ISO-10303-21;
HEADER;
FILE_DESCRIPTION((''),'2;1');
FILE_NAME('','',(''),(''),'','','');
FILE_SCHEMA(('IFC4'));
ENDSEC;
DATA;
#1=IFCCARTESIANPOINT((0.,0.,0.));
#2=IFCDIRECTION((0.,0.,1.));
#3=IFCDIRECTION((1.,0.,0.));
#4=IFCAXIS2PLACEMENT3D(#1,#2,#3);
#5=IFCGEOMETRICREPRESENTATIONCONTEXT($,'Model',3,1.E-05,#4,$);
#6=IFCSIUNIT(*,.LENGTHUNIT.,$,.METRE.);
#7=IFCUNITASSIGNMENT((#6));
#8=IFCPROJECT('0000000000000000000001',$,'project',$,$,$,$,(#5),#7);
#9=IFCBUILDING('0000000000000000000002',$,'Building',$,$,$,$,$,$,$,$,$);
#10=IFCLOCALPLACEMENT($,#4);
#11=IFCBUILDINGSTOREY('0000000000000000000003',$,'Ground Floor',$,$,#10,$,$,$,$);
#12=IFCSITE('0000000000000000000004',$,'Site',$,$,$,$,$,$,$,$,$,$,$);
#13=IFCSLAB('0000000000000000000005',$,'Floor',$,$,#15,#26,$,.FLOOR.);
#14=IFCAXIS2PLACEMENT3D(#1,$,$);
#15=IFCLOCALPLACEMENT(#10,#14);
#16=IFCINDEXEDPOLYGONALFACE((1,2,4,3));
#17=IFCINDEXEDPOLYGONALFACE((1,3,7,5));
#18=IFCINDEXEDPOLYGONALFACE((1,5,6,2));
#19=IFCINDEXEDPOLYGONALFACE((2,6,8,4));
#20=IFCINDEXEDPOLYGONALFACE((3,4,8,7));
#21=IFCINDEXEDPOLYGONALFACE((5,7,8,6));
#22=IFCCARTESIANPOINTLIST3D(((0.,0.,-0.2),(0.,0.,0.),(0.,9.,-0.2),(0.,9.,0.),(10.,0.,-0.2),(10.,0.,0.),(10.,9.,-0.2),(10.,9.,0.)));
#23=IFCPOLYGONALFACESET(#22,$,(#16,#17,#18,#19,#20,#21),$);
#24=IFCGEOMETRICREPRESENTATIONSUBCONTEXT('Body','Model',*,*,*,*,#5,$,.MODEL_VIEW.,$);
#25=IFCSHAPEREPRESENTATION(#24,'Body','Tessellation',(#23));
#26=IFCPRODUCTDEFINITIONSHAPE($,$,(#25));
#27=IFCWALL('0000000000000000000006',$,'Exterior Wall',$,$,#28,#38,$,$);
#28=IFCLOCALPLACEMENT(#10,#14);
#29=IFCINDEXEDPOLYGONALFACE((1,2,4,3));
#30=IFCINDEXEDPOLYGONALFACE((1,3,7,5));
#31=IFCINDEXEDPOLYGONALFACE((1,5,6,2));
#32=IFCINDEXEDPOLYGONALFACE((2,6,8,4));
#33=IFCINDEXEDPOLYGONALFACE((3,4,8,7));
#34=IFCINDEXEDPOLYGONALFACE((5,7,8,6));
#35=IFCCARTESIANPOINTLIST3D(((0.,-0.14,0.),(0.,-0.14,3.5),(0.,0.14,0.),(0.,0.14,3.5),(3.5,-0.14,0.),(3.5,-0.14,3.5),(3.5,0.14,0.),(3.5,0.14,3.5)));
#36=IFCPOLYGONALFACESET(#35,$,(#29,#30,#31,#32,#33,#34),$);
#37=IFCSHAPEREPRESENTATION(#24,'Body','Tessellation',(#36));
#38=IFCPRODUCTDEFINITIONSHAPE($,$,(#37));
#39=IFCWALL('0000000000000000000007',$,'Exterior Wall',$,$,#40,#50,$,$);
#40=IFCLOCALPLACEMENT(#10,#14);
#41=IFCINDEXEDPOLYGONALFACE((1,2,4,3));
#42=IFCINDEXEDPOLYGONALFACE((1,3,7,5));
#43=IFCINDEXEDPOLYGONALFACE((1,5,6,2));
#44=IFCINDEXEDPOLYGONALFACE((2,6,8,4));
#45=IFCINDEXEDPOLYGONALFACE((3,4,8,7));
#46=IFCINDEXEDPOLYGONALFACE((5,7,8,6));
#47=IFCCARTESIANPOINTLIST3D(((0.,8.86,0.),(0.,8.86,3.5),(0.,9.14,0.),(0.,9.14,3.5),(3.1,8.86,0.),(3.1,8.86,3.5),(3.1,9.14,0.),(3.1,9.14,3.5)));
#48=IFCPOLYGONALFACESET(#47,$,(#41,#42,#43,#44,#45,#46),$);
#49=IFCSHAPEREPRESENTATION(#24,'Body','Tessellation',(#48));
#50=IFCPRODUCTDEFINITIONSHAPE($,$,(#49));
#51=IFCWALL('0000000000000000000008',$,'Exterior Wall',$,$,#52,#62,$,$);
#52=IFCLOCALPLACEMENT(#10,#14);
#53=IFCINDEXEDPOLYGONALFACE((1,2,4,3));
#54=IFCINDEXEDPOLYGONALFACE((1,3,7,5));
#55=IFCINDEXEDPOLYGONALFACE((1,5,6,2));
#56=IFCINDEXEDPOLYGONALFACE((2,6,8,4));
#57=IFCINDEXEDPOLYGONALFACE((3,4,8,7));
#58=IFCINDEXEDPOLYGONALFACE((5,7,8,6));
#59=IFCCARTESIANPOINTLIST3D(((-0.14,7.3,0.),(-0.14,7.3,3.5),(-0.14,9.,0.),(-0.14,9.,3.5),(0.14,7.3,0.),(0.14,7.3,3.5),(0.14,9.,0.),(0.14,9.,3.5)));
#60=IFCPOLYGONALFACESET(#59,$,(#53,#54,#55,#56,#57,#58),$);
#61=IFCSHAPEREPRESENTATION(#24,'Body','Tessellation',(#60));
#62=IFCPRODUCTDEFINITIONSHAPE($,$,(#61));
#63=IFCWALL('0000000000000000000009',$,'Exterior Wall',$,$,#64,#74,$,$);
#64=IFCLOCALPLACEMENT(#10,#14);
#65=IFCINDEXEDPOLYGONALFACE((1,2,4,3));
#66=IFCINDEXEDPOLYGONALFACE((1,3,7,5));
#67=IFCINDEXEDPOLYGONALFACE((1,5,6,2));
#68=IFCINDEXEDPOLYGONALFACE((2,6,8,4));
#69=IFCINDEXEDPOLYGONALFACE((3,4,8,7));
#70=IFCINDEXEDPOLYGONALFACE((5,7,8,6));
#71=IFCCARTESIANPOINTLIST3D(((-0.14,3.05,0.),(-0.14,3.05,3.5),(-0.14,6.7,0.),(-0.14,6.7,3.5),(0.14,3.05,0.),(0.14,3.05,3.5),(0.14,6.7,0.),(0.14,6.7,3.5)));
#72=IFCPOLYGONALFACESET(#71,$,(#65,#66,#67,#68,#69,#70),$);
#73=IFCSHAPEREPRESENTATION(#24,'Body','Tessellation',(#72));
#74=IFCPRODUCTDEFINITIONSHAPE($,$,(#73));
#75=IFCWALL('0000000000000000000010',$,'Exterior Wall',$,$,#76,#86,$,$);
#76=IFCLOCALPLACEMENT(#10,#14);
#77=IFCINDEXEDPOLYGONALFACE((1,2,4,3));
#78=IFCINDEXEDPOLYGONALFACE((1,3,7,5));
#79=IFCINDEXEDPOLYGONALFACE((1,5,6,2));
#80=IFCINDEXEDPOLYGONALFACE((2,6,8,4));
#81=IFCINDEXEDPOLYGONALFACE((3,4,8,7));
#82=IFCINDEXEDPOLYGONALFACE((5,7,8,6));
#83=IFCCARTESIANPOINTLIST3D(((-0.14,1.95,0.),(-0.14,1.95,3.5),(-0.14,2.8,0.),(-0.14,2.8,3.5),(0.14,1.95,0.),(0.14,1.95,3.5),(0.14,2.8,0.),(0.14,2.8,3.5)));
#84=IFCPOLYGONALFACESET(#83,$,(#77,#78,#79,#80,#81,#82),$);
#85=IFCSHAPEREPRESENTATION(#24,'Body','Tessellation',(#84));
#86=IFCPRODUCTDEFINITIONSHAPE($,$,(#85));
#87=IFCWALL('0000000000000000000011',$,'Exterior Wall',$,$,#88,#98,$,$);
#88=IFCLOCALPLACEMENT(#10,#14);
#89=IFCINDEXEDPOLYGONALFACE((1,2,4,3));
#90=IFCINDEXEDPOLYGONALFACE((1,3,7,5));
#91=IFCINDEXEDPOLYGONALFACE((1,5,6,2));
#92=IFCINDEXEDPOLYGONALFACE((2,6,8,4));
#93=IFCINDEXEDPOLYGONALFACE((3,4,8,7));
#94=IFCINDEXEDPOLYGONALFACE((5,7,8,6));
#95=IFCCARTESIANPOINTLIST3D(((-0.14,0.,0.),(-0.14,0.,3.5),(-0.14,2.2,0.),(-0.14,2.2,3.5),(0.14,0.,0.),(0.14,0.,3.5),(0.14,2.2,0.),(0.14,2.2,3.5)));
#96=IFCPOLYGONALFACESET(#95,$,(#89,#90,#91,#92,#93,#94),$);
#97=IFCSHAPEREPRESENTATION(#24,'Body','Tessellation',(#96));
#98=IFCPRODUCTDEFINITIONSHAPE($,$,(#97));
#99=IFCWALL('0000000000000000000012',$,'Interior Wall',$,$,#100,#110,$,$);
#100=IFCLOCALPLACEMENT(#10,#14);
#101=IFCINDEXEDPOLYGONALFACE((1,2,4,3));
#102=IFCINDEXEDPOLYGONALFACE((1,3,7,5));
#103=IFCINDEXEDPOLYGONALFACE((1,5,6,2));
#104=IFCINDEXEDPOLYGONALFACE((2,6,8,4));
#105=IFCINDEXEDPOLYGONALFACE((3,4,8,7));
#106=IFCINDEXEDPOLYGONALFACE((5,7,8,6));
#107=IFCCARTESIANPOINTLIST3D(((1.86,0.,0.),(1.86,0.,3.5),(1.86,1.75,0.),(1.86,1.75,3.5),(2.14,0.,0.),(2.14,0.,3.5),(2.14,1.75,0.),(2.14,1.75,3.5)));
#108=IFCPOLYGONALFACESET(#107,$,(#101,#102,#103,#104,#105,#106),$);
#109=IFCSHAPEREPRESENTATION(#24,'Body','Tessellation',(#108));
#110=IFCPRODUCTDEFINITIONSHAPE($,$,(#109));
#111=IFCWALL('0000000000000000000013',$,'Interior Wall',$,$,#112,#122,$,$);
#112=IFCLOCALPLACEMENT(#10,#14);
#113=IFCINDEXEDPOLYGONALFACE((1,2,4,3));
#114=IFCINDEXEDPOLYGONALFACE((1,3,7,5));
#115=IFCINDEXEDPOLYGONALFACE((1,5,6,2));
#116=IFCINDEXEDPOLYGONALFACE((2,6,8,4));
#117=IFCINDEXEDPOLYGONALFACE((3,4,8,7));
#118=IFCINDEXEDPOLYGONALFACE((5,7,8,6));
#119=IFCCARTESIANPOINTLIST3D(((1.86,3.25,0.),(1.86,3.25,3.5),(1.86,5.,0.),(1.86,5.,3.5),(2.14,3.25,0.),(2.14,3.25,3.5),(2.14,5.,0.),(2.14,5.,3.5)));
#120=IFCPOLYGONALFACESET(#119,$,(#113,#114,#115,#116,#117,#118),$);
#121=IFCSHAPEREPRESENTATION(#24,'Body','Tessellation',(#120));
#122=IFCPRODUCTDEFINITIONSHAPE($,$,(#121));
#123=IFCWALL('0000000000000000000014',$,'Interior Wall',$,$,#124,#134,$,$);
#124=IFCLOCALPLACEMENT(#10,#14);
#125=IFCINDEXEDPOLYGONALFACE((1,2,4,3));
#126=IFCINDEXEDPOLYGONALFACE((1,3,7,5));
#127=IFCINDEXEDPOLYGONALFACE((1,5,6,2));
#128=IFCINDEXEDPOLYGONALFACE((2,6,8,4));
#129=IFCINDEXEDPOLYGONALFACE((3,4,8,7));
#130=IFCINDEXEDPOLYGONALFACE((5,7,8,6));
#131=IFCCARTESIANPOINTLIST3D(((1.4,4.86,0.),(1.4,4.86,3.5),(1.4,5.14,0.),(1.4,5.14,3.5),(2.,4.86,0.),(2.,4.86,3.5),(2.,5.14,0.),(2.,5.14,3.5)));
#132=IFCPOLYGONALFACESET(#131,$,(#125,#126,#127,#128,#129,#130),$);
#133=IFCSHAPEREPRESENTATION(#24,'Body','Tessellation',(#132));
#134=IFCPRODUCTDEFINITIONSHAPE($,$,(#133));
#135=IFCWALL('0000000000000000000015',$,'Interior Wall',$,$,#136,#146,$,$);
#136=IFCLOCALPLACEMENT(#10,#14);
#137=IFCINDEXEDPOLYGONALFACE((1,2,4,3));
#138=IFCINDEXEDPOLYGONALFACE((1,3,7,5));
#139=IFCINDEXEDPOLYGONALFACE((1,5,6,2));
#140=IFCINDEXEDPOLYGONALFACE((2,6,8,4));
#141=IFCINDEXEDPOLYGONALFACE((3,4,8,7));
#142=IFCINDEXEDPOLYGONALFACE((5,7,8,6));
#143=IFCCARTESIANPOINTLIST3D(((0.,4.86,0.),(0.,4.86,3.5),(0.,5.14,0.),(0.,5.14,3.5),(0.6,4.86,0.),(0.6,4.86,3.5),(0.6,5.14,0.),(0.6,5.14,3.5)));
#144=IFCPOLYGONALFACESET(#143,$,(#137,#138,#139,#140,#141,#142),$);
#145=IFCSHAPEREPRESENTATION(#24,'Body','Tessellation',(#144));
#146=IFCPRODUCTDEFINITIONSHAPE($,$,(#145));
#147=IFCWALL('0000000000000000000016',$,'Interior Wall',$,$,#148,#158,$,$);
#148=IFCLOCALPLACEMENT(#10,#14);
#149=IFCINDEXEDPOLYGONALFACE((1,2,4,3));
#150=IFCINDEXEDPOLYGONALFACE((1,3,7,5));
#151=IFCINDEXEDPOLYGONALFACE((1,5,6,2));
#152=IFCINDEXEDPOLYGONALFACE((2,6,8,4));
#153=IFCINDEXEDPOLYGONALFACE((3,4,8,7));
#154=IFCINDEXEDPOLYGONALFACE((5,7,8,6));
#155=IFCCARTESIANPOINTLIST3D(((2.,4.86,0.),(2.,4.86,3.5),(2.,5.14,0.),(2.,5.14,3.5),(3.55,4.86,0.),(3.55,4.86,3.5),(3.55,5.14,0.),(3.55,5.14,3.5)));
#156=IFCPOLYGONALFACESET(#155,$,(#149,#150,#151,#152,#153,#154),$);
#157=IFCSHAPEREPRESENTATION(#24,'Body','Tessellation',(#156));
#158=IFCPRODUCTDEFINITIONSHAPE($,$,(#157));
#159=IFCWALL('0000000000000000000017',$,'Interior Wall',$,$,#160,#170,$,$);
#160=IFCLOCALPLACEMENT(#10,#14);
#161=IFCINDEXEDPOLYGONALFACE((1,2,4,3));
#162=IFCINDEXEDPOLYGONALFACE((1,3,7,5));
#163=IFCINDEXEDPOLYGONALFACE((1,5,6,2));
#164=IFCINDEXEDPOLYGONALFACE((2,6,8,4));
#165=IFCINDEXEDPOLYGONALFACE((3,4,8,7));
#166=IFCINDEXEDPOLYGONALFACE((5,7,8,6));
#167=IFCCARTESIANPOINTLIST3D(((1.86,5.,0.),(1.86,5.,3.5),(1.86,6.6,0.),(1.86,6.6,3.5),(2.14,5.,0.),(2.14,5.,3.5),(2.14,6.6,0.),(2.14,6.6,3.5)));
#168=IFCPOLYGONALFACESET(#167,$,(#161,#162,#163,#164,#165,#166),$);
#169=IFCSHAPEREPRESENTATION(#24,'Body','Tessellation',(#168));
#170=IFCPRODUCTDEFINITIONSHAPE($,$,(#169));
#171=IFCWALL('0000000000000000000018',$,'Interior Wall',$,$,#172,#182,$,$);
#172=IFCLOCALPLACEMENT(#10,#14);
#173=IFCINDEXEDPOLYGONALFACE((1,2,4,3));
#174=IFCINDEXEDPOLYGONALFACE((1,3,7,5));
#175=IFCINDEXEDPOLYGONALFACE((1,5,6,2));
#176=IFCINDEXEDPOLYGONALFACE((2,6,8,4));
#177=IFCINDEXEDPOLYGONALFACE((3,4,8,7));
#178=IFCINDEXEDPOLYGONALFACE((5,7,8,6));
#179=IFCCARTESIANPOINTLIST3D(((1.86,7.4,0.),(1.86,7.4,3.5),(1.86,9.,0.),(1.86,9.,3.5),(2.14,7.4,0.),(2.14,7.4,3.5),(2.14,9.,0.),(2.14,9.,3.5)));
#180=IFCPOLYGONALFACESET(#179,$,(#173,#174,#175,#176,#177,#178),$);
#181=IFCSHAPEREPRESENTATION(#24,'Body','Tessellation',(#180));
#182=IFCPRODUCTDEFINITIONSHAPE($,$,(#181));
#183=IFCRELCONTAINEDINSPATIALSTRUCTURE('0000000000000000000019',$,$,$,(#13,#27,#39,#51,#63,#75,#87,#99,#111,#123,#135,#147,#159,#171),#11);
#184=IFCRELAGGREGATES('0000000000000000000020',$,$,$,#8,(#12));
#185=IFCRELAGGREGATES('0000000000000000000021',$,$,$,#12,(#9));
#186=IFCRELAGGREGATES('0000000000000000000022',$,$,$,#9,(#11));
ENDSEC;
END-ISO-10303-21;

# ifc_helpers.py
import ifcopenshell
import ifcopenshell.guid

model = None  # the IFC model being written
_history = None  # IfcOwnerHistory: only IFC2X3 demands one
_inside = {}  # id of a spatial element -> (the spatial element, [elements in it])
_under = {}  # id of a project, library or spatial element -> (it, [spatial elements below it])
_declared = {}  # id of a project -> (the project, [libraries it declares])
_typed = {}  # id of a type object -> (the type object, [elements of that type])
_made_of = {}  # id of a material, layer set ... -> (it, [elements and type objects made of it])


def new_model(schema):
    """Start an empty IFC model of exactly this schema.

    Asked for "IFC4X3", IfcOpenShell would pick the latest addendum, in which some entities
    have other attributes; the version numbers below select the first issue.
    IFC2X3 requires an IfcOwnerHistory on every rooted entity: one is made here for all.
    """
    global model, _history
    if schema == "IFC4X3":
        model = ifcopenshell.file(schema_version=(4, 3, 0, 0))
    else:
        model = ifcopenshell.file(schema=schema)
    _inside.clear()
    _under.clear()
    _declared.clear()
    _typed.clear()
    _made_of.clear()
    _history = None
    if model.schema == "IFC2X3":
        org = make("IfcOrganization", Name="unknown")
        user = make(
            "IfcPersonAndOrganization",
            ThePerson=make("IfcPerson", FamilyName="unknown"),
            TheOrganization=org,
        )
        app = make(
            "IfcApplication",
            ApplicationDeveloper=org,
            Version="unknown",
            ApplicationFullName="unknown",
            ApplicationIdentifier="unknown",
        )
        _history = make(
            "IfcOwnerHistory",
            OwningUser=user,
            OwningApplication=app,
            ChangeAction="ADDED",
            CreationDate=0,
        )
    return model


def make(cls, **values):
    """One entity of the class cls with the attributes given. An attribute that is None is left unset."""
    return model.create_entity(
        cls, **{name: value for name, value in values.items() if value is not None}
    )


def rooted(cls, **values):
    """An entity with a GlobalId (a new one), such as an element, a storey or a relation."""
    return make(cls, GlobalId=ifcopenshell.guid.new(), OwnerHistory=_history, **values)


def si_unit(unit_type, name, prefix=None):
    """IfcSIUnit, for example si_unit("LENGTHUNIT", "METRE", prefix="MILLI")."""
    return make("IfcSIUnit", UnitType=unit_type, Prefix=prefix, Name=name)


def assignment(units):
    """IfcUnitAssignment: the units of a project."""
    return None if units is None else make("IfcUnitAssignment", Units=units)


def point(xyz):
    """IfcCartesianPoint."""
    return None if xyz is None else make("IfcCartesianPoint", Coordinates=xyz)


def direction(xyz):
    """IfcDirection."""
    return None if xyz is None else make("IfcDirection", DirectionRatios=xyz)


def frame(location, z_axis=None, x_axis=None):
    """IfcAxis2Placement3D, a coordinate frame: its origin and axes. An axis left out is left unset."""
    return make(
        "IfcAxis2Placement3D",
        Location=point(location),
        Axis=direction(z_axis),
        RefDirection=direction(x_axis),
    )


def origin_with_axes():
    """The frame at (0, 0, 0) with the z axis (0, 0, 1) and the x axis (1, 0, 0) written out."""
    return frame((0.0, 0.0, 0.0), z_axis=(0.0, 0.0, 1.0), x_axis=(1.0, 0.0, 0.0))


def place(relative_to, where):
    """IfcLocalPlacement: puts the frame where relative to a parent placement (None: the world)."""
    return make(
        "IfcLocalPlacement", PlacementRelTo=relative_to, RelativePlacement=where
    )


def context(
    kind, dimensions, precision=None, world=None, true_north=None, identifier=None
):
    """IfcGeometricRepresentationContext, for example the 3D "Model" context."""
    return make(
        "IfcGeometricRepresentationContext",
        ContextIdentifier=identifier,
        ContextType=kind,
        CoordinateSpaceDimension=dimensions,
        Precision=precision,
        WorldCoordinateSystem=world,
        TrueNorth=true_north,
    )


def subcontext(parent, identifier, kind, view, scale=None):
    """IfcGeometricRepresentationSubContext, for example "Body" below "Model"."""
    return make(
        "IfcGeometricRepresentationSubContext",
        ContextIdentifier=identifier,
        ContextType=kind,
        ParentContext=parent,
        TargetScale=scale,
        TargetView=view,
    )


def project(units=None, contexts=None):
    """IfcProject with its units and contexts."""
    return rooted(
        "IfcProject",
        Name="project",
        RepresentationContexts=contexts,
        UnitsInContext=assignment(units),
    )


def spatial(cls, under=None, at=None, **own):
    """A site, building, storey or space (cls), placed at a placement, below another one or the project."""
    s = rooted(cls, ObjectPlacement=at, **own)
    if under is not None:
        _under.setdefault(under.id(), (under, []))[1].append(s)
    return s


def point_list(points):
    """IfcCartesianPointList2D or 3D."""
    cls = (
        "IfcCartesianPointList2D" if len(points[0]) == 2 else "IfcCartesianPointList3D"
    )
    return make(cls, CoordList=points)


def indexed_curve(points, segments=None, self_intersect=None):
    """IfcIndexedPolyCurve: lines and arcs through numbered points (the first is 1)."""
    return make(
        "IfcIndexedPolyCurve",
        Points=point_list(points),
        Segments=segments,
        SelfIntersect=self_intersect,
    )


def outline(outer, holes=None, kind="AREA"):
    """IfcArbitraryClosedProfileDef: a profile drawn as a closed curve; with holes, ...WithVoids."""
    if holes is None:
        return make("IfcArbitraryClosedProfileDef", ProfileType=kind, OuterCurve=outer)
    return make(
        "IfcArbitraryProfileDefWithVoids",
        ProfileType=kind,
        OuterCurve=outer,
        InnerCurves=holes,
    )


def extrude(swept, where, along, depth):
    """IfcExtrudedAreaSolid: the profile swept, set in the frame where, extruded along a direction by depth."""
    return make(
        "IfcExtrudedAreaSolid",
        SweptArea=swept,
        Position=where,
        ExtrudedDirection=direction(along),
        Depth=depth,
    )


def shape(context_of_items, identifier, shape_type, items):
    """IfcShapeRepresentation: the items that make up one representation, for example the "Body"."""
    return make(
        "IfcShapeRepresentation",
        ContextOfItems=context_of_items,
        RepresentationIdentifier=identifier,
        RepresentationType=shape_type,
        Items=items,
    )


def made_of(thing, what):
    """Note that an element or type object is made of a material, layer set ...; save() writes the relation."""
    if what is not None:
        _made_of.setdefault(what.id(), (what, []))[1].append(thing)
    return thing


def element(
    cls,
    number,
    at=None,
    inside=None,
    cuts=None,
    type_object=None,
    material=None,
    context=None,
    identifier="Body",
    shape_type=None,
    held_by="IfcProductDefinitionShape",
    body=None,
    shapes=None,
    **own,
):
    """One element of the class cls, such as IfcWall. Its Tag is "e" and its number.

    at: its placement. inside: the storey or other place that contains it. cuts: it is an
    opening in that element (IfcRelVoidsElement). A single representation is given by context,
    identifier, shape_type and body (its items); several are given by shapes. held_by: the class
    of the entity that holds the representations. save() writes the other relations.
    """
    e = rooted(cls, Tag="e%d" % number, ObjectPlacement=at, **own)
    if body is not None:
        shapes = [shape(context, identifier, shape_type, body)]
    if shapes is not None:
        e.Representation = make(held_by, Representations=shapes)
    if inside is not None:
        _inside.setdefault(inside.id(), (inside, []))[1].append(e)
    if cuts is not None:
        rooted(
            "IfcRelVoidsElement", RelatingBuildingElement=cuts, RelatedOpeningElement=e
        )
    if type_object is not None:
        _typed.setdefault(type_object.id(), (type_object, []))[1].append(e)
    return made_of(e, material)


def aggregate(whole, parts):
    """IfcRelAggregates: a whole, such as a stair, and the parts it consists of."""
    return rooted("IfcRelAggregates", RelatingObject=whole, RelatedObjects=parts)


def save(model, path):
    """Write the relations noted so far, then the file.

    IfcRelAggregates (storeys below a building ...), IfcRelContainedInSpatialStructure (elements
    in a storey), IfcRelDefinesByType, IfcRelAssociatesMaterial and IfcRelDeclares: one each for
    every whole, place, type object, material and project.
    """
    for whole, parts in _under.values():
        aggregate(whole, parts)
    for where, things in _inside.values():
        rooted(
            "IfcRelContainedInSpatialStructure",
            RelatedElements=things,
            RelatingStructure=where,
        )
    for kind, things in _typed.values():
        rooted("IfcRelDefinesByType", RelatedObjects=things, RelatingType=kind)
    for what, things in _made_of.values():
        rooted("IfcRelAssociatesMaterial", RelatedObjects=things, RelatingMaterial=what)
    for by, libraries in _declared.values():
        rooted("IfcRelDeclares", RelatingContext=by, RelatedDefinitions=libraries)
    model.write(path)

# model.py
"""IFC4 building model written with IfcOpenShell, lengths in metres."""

from ifc_helpers import new_model, si_unit, frame, origin_with_axes, place, context, subcontext, project, spatial, indexed_curve, outline, extrude, element, save


model = new_model("IFC4")

# Units and contexts
model_context = context("Model", 3, precision=1e-05, world=origin_with_axes())
body_context = subcontext(model_context, "Body", "Model", "MODEL_VIEW")
ifc_project = project(units=[si_unit("LENGTHUNIT", "METRE")], contexts=[model_context])

# Site, building, storey
site = spatial("IfcSite", under=ifc_project, Name="Site")
building = spatial("IfcBuilding", under=site, Name="Building")
storey_placement = place(None, origin_with_axes())
storey = spatial("IfcBuildingStorey", under=building, at=storey_placement, Name="Ground Floor")

# Slab
slab_placement = place(storey_placement, frame((0.0, 0.0, -0.2), z_axis=(0.0, 0.0, 1.0), x_axis=(1.0, 0.0, 0.0)))
element("IfcSlab", 1, at=slab_placement, inside=storey, Name="Floor", PredefinedType="FLOOR", context=body_context, shape_type="SweptSolid", body=[
    extrude(outline(indexed_curve([(0.0, 0.0), (10.0, 0.0), (10.0, 9.0), (0.0, 9.0)])), None, (0.0, 0.0, 1.0), 0.2),
])

# Walls
wall_1_placement = place(storey_placement, origin_with_axes())
element("IfcWall", 2, at=wall_1_placement, inside=storey, Name="Exterior Wall", context=body_context, shape_type="SweptSolid", body=[
    extrude(outline(indexed_curve([(0.0, 0.0), (0.0, 0.28), (3.5, 0.28), (3.5, 0.0), (0.0, 0.0)], self_intersect=False)), frame((0.0, -0.14, 0.0), z_axis=(0.0, 0.0, 1.0), x_axis=(1.0, 0.0, 0.0)), (0.0, 0.0, 1.0), 3.5),
])
wall_2_placement = place(storey_placement, frame((3.1, 9.0, 0.0), z_axis=(0.0, 0.0, 1.0), x_axis=(-1.0, 0.0, 0.0)))
element("IfcWall", 3, at=wall_2_placement, inside=storey, Name="Exterior Wall", context=body_context, shape_type="SweptSolid", body=[
    extrude(outline(indexed_curve([(0.0, 0.0), (0.0, 0.28), (3.1, 0.28), (3.1, 0.0), (0.0, 0.0)], self_intersect=False)), frame((0.0, -0.14, 0.0), z_axis=(0.0, 0.0, 1.0), x_axis=(1.0, 0.0, 0.0)), (0.0, 0.0, 1.0), 3.5),
])
wall_3_placement = place(storey_placement, frame((0.0, 9.0, 0.0), z_axis=(0.0, 0.0, 1.0), x_axis=(0.0, -1.0, 0.0)))
element("IfcWall", 4, at=wall_3_placement, inside=storey, Name="Exterior Wall", context=body_context, shape_type="SweptSolid", body=[
    extrude(outline(indexed_curve([(0.0, 0.0), (0.0, 0.28), (1.7, 0.28), (1.7, 0.0), (0.0, 0.0)], self_intersect=False)), frame((0.0, -0.14, 0.0), z_axis=(0.0, 0.0, 1.0), x_axis=(1.0, 0.0, 0.0)), (0.0, 0.0, 1.0), 3.5),
])
wall_4_placement = place(storey_placement, frame((0.0, 6.7, 0.0), z_axis=(0.0, 0.0, 1.0), x_axis=(0.0, -1.0, 0.0)))
element("IfcWall", 5, at=wall_4_placement, inside=storey, Name="Exterior Wall", context=body_context, shape_type="SweptSolid", body=[
    extrude(outline(indexed_curve([(0.0, 0.0), (0.0, 0.28), (3.65, 0.28), (3.65, 0.0), (0.0, 0.0)], self_intersect=False)), frame((0.0, -0.14, 0.0), z_axis=(0.0, 0.0, 1.0), x_axis=(1.0, 0.0, 0.0)), (0.0, 0.0, 1.0), 3.5),
])
wall_5_placement = place(storey_placement, frame((0.0, 1.95, 0.0), z_axis=(0.0, 0.0, 1.0), x_axis=(0.0, 1.0, 0.0)))
element("IfcWall", 6, at=wall_5_placement, inside=storey, Name="Exterior Wall", context=body_context, shape_type="SweptSolid", body=[
    extrude(outline(indexed_curve([(0.0, 0.0), (0.0, 0.28), (0.85, 0.28), (0.85, 0.0), (0.0, 0.0)], self_intersect=False)), frame((0.0, -0.14, 0.0), z_axis=(0.0, 0.0, 1.0), x_axis=(1.0, 0.0, 0.0)), (0.0, 0.0, 1.0), 3.5),
])
wall_6_placement = place(storey_placement, frame((0.0, 2.2, 0.0), z_axis=(0.0, 0.0, 1.0), x_axis=(0.0, -1.0, 0.0)))
element("IfcWall", 7, at=wall_6_placement, inside=storey, Name="Exterior Wall", context=body_context, shape_type="SweptSolid", body=[
    extrude(outline(indexed_curve([(0.0, 0.0), (0.0, 0.28), (2.2, 0.28), (2.2, 0.0), (0.0, 0.0)], self_intersect=False)), frame((0.0, -0.14, 0.0), z_axis=(0.0, 0.0, 1.0), x_axis=(1.0, 0.0, 0.0)), (0.0, 0.0, 1.0), 3.5),
])
for number, where, z_axis, x_axis, name in (
    (8, (2.0, 0.0, 0.0), (0.0, 0.0, 1.0), (0.0, 1.0, 0.0), "Interior Wall"),
    (9, (2.0, 3.25, 0.0), (0.0, 0.0, 1.0), (0.0, 1.0, 0.0), "Interior Wall"),
):
    element("IfcWall", number, at=place(storey_placement, frame(where, z_axis=z_axis, x_axis=x_axis)), inside=storey, Name=name, context=body_context, shape_type="SweptSolid", body=[
        extrude(outline(indexed_curve([(0.0, 0.0), (0.0, 0.28), (1.75, 0.28), (1.75, 0.0), (0.0, 0.0)], self_intersect=False)), frame((0.0, -0.14, 0.0), z_axis=(0.0, 0.0, 1.0), x_axis=(1.0, 0.0, 0.0)), (0.0, 0.0, 1.0), 3.5),
    ])
for number, where, z_axis, x_axis, name in (
    (10, (2.0, 5.0, 0.0), (0.0, 0.0, 1.0), (-1.0, 0.0, 0.0), "Interior Wall"),
    (11, (0.6, 5.0, 0.0), (0.0, 0.0, 1.0), (-1.0, 0.0, 0.0), "Interior Wall"),
):
    element("IfcWall", number, at=place(storey_placement, frame(where, z_axis=z_axis, x_axis=x_axis)), inside=storey, Name=name, context=body_context, shape_type="SweptSolid", body=[
        extrude(outline(indexed_curve([(0.0, 0.0), (0.0, 0.28), (0.6, 0.28), (0.6, 0.0), (0.0, 0.0)], self_intersect=False)), frame((0.0, -0.14, 0.0), z_axis=(0.0, 0.0, 1.0), x_axis=(1.0, 0.0, 0.0)), (0.0, 0.0, 1.0), 3.5),
    ])
wall_7_placement = place(storey_placement, frame((3.55, 5.0, 0.0), z_axis=(0.0, 0.0, 1.0), x_axis=(-1.0, 0.0, 0.0)))
element("IfcWall", 12, at=wall_7_placement, inside=storey, Name="Interior Wall", context=body_context, shape_type="SweptSolid", body=[
    extrude(outline(indexed_curve([(0.0, 0.0), (0.0, 0.28), (1.55, 0.28), (1.55, 0.0), (0.0, 0.0)], self_intersect=False)), frame((0.0, -0.14, 0.0), z_axis=(0.0, 0.0, 1.0), x_axis=(1.0, 0.0, 0.0)), (0.0, 0.0, 1.0), 3.5),
])
for number, where, z_axis, x_axis, name in (
    (13, (2.0, 5.0, 0.0), (0.0, 0.0, 1.0), (0.0, 1.0, 0.0), "Interior Wall"),
    (14, (2.0, 7.4, 0.0), (0.0, 0.0, 1.0), (0.0, 1.0, 0.0), "Interior Wall"),
):
    element("IfcWall", number, at=place(storey_placement, frame(where, z_axis=z_axis, x_axis=x_axis)), inside=storey, Name=name, context=body_context, shape_type="SweptSolid", body=[
        extrude(outline(indexed_curve([(0.0, 0.0), (0.0, 0.28), (1.6, 0.28), (1.6, 0.0), (0.0, 0.0)], self_intersect=False)), frame((0.0, -0.14, 0.0), z_axis=(0.0, 0.0, 1.0), x_axis=(1.0, 0.0, 0.0)), (0.0, 0.0, 1.0), 3.5),
    ])

save(model, "model.ifc")
